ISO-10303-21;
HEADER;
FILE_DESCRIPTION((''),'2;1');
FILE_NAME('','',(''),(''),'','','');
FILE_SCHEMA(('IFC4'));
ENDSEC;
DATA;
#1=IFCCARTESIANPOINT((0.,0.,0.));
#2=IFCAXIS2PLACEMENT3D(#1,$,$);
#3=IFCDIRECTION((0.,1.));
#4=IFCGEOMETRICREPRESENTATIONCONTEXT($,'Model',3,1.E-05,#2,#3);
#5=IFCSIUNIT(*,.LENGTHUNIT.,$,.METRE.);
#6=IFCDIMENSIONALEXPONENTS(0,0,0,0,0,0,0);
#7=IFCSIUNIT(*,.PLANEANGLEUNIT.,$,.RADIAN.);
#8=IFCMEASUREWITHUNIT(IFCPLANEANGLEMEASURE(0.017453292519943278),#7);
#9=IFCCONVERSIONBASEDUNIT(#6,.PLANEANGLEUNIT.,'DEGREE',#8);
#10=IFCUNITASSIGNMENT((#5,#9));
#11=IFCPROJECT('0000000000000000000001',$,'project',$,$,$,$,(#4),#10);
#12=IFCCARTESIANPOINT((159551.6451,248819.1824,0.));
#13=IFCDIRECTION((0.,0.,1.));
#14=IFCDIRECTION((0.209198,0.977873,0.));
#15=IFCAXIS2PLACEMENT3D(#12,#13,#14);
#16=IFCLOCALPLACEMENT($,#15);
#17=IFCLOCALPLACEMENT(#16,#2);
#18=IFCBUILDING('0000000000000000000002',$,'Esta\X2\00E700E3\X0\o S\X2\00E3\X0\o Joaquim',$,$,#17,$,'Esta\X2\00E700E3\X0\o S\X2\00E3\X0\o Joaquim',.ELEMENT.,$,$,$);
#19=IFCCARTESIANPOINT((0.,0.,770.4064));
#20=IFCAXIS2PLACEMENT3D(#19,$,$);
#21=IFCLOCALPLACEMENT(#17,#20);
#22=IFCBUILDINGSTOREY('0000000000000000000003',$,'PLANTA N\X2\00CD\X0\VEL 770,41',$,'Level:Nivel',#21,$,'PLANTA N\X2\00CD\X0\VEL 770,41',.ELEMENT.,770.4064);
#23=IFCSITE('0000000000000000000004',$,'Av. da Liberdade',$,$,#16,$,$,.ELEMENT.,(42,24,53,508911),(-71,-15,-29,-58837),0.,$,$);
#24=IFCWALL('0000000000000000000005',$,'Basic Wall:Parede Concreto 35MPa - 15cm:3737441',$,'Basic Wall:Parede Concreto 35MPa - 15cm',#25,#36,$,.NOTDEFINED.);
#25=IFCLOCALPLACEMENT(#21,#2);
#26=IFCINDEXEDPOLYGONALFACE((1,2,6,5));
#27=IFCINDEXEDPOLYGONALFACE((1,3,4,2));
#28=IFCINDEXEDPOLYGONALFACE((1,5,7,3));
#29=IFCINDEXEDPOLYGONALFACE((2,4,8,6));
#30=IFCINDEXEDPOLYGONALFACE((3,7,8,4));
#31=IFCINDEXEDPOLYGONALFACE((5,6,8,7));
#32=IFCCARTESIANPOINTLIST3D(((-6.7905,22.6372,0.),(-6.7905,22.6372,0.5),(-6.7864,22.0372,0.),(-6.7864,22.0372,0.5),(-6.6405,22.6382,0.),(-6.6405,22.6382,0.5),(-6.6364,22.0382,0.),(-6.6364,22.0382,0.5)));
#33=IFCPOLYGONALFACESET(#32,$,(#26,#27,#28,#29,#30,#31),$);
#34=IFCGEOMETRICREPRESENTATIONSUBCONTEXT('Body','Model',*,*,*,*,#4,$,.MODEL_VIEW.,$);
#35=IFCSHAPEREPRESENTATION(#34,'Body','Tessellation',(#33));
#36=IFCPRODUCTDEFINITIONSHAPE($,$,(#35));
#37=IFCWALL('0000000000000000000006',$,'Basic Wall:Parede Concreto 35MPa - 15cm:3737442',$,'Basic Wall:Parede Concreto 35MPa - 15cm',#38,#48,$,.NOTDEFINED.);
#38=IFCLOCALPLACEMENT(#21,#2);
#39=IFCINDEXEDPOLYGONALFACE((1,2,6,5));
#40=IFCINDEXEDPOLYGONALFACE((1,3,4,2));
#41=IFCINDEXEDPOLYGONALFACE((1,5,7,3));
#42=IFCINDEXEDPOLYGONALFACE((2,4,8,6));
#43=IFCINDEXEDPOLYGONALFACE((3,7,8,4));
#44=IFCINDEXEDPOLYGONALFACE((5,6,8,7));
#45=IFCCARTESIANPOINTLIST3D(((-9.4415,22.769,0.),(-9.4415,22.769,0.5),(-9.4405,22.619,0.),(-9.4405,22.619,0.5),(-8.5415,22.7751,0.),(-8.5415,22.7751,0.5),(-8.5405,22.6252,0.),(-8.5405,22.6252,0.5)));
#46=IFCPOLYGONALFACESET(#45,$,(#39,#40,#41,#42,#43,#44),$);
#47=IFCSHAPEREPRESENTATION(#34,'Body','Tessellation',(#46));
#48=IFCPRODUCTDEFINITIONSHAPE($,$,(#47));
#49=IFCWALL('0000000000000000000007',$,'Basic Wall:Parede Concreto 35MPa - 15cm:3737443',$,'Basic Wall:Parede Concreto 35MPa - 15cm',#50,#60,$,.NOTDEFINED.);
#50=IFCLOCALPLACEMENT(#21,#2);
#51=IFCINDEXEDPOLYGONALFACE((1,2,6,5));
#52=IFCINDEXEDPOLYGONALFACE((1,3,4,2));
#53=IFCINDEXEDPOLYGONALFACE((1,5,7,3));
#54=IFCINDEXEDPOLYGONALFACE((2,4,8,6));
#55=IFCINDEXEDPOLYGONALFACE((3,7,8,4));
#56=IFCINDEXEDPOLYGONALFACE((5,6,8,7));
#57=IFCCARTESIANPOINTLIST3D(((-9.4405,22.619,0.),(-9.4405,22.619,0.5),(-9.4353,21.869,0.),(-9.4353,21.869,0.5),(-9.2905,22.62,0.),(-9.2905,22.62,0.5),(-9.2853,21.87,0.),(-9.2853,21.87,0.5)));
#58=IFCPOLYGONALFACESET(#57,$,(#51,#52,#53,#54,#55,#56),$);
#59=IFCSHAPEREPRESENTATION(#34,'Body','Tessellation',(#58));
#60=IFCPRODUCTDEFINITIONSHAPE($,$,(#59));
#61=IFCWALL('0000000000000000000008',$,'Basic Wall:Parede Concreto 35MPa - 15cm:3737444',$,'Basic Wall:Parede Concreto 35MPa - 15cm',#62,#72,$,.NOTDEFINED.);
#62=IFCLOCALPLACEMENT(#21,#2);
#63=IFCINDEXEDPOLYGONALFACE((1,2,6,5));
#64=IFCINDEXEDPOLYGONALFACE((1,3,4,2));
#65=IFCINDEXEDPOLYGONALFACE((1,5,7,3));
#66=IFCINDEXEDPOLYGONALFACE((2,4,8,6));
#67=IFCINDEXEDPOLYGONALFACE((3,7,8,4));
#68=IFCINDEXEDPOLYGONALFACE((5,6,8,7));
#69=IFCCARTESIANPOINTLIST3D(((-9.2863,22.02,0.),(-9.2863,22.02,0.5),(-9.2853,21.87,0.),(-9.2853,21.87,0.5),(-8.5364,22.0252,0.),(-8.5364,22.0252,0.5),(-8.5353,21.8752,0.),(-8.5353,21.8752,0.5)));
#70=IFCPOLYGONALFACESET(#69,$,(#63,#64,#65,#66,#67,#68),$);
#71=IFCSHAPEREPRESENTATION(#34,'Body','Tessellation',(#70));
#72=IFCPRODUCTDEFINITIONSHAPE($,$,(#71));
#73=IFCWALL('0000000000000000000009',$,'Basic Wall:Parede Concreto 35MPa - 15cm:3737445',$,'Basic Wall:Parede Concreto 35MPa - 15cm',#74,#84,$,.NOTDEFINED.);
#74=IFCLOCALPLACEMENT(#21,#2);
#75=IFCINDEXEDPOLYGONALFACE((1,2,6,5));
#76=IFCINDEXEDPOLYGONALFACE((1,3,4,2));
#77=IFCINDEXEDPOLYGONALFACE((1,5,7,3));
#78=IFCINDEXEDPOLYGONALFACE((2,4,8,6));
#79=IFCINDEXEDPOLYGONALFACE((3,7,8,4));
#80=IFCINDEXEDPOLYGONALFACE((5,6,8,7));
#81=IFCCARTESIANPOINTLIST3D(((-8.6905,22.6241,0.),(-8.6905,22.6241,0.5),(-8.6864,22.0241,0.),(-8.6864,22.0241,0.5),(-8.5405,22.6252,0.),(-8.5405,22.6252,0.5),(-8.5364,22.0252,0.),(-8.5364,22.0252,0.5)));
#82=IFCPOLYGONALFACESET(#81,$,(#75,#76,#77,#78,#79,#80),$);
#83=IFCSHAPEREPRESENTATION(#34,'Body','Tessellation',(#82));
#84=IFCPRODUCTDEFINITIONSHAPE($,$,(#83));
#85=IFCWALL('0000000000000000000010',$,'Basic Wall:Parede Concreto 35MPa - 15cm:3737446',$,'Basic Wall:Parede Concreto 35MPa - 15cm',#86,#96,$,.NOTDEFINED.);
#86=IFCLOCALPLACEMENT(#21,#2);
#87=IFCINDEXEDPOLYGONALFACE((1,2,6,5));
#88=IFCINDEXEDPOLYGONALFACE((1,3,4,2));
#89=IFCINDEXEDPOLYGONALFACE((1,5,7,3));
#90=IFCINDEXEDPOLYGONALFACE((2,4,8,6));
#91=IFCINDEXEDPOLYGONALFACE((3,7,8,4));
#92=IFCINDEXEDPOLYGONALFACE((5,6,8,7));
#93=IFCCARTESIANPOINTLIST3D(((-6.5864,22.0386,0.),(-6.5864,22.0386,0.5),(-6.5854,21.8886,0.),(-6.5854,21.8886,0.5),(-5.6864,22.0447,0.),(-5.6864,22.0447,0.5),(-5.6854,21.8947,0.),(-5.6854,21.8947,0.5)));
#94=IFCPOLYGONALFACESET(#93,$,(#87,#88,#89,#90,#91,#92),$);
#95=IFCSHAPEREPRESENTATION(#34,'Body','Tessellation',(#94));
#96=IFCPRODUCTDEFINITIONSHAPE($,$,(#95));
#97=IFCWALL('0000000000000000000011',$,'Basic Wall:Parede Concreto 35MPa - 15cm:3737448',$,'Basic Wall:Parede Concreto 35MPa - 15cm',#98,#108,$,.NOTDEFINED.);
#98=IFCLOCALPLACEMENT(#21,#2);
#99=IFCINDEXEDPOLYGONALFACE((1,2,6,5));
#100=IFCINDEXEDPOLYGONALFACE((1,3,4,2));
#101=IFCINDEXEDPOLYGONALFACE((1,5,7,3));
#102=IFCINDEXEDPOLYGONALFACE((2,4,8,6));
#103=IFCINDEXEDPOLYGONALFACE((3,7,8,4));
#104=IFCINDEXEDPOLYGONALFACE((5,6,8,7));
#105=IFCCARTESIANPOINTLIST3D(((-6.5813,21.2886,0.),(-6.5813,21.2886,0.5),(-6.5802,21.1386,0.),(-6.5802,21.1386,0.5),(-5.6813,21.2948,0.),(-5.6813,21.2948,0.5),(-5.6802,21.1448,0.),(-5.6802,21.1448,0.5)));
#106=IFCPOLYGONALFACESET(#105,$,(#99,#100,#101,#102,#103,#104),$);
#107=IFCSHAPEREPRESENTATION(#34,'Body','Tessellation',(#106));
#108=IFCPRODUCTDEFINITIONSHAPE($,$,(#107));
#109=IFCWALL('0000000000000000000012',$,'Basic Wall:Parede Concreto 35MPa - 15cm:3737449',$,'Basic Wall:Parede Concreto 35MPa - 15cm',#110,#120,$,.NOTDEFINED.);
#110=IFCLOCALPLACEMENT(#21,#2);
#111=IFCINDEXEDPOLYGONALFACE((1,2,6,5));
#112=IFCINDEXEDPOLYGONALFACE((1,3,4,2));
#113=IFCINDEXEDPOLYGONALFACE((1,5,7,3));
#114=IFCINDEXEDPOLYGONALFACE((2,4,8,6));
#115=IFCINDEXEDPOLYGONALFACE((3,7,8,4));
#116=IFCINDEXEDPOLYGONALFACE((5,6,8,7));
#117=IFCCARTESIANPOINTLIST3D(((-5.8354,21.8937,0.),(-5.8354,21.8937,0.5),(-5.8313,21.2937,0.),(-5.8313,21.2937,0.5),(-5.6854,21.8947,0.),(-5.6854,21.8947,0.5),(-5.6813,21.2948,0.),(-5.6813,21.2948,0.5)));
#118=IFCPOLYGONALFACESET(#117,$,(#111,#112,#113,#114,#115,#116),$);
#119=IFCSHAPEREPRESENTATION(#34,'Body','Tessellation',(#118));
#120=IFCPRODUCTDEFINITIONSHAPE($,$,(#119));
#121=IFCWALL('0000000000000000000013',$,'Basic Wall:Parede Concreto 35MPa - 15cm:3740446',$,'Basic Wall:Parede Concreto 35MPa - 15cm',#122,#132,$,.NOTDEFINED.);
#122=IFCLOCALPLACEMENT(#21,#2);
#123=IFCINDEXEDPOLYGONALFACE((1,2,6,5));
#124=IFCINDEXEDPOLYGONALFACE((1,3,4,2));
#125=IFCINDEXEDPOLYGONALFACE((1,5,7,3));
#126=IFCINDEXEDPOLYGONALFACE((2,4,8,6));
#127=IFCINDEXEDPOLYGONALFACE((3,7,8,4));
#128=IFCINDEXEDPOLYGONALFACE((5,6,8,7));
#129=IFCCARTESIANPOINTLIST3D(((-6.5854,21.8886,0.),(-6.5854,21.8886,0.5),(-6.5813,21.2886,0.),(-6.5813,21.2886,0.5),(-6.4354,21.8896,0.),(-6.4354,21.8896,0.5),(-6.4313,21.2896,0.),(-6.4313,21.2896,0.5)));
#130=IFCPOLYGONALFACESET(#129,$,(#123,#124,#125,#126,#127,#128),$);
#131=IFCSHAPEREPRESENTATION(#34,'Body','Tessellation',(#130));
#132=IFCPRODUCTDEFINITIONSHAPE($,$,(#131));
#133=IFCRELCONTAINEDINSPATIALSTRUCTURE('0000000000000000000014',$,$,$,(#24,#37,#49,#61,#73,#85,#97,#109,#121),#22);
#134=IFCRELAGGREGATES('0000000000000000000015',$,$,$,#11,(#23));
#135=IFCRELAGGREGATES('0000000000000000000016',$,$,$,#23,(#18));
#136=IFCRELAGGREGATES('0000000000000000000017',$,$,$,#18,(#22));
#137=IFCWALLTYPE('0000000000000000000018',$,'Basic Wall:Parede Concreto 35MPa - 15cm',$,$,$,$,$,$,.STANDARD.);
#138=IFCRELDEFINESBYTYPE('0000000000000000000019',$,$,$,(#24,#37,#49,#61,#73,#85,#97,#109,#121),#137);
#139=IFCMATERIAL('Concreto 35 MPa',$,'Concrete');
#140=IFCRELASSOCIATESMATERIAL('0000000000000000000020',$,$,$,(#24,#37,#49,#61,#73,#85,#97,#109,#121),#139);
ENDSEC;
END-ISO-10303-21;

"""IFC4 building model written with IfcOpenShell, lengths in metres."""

from ifc_helpers import new_model, entity, si_unit, converted_unit, direction, frame, origin, place, context, subcontext, project, spatial, indexed_curve, outline, extrude, material, type_object, element, save


model = new_model("IFC4")

# Units and contexts
model_context = context("Model", 3, precision=1e-05, world=origin(), true_north=direction((0.0, 1.0)))
body_context = subcontext(model_context, "Body", "Model", "MODEL_VIEW")
ifc_project = project(units=[si_unit("LENGTHUNIT", "METRE"), converted_unit("PLANEANGLEUNIT", "DEGREE", entity("IfcPlaneAngleMeasure", 0.017453292519943278), si_unit("PLANEANGLEUNIT", "RADIAN"), dimensions=[0, 0, 0, 0, 0, 0, 0])], contexts=[model_context])

# Site, building, storey
site_placement = place(None, frame((159551.6451, 248819.1824, 0.0), z_axis=(0.0, 0.0, 1.0), x_axis=(0.209198, 0.977873, 0.0)))
site = spatial("IfcSite", under=ifc_project, at=site_placement, Name="Av. da Liberdade", CompositionType="ELEMENT", RefLatitude=(42, 24, 53, 508911), RefLongitude=(-71, -15, -29, -58837), RefElevation=0.0)
building_placement = place(site_placement, origin())
building = spatial("IfcBuilding", under=site, at=building_placement, Name="Estação São Joaquim", LongName="Estação São Joaquim", CompositionType="ELEMENT")
storey_placement = place(building_placement, frame((0.0, 0.0, 770.4064)))
storey = spatial("IfcBuildingStorey", under=building, at=storey_placement, Name="PLANTA NÍVEL 770,41", ObjectType="Level:Nivel", LongName="PLANTA NÍVEL 770,41", CompositionType="ELEMENT", Elevation=770.4064)

# Shared definitions
ifc_material = material(Name="Concreto 35 MPa", Category="Concrete")

# Walls
wall_type_1 = type_object("IfcWallType", Name="Basic Wall:Parede Concreto 35MPa - 15cm", PredefinedType="STANDARD")
wall_1_placement = place(storey_placement, frame((-6.7114, 22.0377, 0.0), z_axis=(0.0, 0.0, 1.0), x_axis=(-0.006868, 0.999976, 0.0)))
element("IfcWall", 1, at=wall_1_placement, inside=storey, type_object=wall_type_1, material=ifc_material, Name="Basic Wall:Parede Concreto 35MPa - 15cm:3737441", ObjectType="Basic Wall:Parede Concreto 35MPa - 15cm", PredefinedType="NOTDEFINED", context=body_context, shape_type="SweptSolid", body=[
    extrude(outline(indexed_curve([(0.6, 0.075), (0.0, 0.075), (0.0, -0.075), (0.6, -0.075), (0.6, 0.075)], self_intersect=False)), origin(), (0.0, 0.0, 1.0), 0.5),
])
wall_2_placement = place(storey_placement, frame((-8.541, 22.7001, 0.0), z_axis=(0.0, 0.0, 1.0), x_axis=(-0.999976, -0.006868, 0.0)))
element("IfcWall", 2, at=wall_2_placement, inside=storey, type_object=wall_type_1, material=ifc_material, Name="Basic Wall:Parede Concreto 35MPa - 15cm:3737442", ObjectType="Basic Wall:Parede Concreto 35MPa - 15cm", PredefinedType="NOTDEFINED", context=body_context, shape_type="SweptSolid", body=[
    extrude(outline(indexed_curve([(0.9, 0.075), (0.0, 0.075), (0.0, -0.075), (0.9, -0.075), (0.9, 0.075)], self_intersect=False)), origin(), (0.0, 0.0, 1.0), 0.5),
])
wall_3_placement = place(storey_placement, frame((-9.3655, 22.6195, 0.0), z_axis=(0.0, 0.0, 1.0), x_axis=(0.006868, -0.999976, 0.0)))
element("IfcWall", 3, at=wall_3_placement, inside=storey, type_object=wall_type_1, material=ifc_material, Name="Basic Wall:Parede Concreto 35MPa - 15cm:3737443", ObjectType="Basic Wall:Parede Concreto 35MPa - 15cm", PredefinedType="NOTDEFINED", context=body_context, shape_type="SweptSolid", body=[
    extrude(outline(indexed_curve([(0.75, 0.075), (0.0, 0.075), (0.0, -0.075), (0.75, -0.075), (0.75, 0.075)], self_intersect=False)), origin(), (0.0, 0.0, 1.0), 0.5),
])
wall_4_placement = place(storey_placement, frame((-9.2858, 21.945, 0.0), z_axis=(0.0, 0.0, 1.0), x_axis=(0.999976, 0.006868, 0.0)))
element("IfcWall", 4, at=wall_4_placement, inside=storey, type_object=wall_type_1, material=ifc_material, Name="Basic Wall:Parede Concreto 35MPa - 15cm:3737444", ObjectType="Basic Wall:Parede Concreto 35MPa - 15cm", PredefinedType="NOTDEFINED", context=body_context, shape_type="SweptSolid", body=[
    extrude(outline(indexed_curve([(0.75, 0.075), (0.0, 0.075), (0.0, -0.075), (0.75, -0.075), (0.75, 0.075)], self_intersect=False)), origin(), (0.0, 0.0, 1.0), 0.5),
])
wall_5_placement = place(storey_placement, frame((-8.6114, 22.0246, 0.0), z_axis=(0.0, 0.0, 1.0), x_axis=(-0.006868, 0.999976, 0.0)))
element("IfcWall", 5, at=wall_5_placement, inside=storey, type_object=wall_type_1, material=ifc_material, Name="Basic Wall:Parede Concreto 35MPa - 15cm:3737445", ObjectType="Basic Wall:Parede Concreto 35MPa - 15cm", PredefinedType="NOTDEFINED", context=body_context, shape_type="SweptSolid", body=[
    extrude(outline(indexed_curve([(0.6, 0.075), (0.0, 0.075), (0.0, -0.075), (0.6, -0.075), (0.6, 0.075)], self_intersect=False)), origin(), (0.0, 0.0, 1.0), 0.5),
])
wall_6_placement = place(storey_placement, frame((-5.6859, 21.9697, 0.0), z_axis=(0.0, 0.0, 1.0), x_axis=(-0.999976, -0.006868, 0.0)))
element("IfcWall", 6, at=wall_6_placement, inside=storey, type_object=wall_type_1, material=ifc_material, Name="Basic Wall:Parede Concreto 35MPa - 15cm:3737446", ObjectType="Basic Wall:Parede Concreto 35MPa - 15cm", PredefinedType="NOTDEFINED", context=body_context, shape_type="SweptSolid", body=[
    extrude(outline(indexed_curve([(0.9, 0.075), (0.0, 0.075), (0.0, -0.075), (0.9, -0.075), (0.9, 0.075)], self_intersect=False)), origin(), (0.0, 0.0, 1.0), 0.5),
])
wall_7_placement = place(storey_placement, frame((-6.5807, 21.2136, 0.0), z_axis=(0.0, 0.0, 1.0), x_axis=(0.999976, 0.006868, 0.0)))
element("IfcWall", 7, at=wall_7_placement, inside=storey, type_object=wall_type_1, material=ifc_material, Name="Basic Wall:Parede Concreto 35MPa - 15cm:3737448", ObjectType="Basic Wall:Parede Concreto 35MPa - 15cm", PredefinedType="NOTDEFINED", context=body_context, shape_type="SweptSolid", body=[
    extrude(outline(indexed_curve([(0.9, 0.075), (0.0, 0.075), (0.0, -0.075), (0.9, -0.075), (0.9, 0.075)], self_intersect=False)), origin(), (0.0, 0.0, 1.0), 0.5),
])
wall_8_placement = place(storey_placement, frame((-5.7563, 21.2942, 0.0), z_axis=(0.0, 0.0, 1.0), x_axis=(-0.006868, 0.999976, 0.0)))
element("IfcWall", 8, at=wall_8_placement, inside=storey, type_object=wall_type_1, material=ifc_material, Name="Basic Wall:Parede Concreto 35MPa - 15cm:3737449", ObjectType="Basic Wall:Parede Concreto 35MPa - 15cm", PredefinedType="NOTDEFINED", context=body_context, shape_type="SweptSolid", body=[
    extrude(outline(indexed_curve([(0.6, 0.075), (0.0, 0.075), (0.0, -0.075), (0.6, -0.075), (0.6, 0.075)], self_intersect=False)), origin(), (0.0, 0.0, 1.0), 0.5),
])
wall_9_placement = place(storey_placement, frame((-6.5063, 21.2891, 0.0), z_axis=(0.0, 0.0, 1.0), x_axis=(-0.006868, 0.999976, 0.0)))
element("IfcWall", 9, at=wall_9_placement, inside=storey, type_object=wall_type_1, material=ifc_material, Name="Basic Wall:Parede Concreto 35MPa - 15cm:3740446", ObjectType="Basic Wall:Parede Concreto 35MPa - 15cm", PredefinedType="NOTDEFINED", context=body_context, shape_type="SweptSolid", body=[
    extrude(outline(indexed_curve([(0.6, 0.075), (0.0, 0.075), (0.0, -0.075), (0.6, -0.075), (0.6, 0.075)], self_intersect=False)), origin(), (0.0, 0.0, 1.0), 0.5),
])

save(model, "model.ifc")
